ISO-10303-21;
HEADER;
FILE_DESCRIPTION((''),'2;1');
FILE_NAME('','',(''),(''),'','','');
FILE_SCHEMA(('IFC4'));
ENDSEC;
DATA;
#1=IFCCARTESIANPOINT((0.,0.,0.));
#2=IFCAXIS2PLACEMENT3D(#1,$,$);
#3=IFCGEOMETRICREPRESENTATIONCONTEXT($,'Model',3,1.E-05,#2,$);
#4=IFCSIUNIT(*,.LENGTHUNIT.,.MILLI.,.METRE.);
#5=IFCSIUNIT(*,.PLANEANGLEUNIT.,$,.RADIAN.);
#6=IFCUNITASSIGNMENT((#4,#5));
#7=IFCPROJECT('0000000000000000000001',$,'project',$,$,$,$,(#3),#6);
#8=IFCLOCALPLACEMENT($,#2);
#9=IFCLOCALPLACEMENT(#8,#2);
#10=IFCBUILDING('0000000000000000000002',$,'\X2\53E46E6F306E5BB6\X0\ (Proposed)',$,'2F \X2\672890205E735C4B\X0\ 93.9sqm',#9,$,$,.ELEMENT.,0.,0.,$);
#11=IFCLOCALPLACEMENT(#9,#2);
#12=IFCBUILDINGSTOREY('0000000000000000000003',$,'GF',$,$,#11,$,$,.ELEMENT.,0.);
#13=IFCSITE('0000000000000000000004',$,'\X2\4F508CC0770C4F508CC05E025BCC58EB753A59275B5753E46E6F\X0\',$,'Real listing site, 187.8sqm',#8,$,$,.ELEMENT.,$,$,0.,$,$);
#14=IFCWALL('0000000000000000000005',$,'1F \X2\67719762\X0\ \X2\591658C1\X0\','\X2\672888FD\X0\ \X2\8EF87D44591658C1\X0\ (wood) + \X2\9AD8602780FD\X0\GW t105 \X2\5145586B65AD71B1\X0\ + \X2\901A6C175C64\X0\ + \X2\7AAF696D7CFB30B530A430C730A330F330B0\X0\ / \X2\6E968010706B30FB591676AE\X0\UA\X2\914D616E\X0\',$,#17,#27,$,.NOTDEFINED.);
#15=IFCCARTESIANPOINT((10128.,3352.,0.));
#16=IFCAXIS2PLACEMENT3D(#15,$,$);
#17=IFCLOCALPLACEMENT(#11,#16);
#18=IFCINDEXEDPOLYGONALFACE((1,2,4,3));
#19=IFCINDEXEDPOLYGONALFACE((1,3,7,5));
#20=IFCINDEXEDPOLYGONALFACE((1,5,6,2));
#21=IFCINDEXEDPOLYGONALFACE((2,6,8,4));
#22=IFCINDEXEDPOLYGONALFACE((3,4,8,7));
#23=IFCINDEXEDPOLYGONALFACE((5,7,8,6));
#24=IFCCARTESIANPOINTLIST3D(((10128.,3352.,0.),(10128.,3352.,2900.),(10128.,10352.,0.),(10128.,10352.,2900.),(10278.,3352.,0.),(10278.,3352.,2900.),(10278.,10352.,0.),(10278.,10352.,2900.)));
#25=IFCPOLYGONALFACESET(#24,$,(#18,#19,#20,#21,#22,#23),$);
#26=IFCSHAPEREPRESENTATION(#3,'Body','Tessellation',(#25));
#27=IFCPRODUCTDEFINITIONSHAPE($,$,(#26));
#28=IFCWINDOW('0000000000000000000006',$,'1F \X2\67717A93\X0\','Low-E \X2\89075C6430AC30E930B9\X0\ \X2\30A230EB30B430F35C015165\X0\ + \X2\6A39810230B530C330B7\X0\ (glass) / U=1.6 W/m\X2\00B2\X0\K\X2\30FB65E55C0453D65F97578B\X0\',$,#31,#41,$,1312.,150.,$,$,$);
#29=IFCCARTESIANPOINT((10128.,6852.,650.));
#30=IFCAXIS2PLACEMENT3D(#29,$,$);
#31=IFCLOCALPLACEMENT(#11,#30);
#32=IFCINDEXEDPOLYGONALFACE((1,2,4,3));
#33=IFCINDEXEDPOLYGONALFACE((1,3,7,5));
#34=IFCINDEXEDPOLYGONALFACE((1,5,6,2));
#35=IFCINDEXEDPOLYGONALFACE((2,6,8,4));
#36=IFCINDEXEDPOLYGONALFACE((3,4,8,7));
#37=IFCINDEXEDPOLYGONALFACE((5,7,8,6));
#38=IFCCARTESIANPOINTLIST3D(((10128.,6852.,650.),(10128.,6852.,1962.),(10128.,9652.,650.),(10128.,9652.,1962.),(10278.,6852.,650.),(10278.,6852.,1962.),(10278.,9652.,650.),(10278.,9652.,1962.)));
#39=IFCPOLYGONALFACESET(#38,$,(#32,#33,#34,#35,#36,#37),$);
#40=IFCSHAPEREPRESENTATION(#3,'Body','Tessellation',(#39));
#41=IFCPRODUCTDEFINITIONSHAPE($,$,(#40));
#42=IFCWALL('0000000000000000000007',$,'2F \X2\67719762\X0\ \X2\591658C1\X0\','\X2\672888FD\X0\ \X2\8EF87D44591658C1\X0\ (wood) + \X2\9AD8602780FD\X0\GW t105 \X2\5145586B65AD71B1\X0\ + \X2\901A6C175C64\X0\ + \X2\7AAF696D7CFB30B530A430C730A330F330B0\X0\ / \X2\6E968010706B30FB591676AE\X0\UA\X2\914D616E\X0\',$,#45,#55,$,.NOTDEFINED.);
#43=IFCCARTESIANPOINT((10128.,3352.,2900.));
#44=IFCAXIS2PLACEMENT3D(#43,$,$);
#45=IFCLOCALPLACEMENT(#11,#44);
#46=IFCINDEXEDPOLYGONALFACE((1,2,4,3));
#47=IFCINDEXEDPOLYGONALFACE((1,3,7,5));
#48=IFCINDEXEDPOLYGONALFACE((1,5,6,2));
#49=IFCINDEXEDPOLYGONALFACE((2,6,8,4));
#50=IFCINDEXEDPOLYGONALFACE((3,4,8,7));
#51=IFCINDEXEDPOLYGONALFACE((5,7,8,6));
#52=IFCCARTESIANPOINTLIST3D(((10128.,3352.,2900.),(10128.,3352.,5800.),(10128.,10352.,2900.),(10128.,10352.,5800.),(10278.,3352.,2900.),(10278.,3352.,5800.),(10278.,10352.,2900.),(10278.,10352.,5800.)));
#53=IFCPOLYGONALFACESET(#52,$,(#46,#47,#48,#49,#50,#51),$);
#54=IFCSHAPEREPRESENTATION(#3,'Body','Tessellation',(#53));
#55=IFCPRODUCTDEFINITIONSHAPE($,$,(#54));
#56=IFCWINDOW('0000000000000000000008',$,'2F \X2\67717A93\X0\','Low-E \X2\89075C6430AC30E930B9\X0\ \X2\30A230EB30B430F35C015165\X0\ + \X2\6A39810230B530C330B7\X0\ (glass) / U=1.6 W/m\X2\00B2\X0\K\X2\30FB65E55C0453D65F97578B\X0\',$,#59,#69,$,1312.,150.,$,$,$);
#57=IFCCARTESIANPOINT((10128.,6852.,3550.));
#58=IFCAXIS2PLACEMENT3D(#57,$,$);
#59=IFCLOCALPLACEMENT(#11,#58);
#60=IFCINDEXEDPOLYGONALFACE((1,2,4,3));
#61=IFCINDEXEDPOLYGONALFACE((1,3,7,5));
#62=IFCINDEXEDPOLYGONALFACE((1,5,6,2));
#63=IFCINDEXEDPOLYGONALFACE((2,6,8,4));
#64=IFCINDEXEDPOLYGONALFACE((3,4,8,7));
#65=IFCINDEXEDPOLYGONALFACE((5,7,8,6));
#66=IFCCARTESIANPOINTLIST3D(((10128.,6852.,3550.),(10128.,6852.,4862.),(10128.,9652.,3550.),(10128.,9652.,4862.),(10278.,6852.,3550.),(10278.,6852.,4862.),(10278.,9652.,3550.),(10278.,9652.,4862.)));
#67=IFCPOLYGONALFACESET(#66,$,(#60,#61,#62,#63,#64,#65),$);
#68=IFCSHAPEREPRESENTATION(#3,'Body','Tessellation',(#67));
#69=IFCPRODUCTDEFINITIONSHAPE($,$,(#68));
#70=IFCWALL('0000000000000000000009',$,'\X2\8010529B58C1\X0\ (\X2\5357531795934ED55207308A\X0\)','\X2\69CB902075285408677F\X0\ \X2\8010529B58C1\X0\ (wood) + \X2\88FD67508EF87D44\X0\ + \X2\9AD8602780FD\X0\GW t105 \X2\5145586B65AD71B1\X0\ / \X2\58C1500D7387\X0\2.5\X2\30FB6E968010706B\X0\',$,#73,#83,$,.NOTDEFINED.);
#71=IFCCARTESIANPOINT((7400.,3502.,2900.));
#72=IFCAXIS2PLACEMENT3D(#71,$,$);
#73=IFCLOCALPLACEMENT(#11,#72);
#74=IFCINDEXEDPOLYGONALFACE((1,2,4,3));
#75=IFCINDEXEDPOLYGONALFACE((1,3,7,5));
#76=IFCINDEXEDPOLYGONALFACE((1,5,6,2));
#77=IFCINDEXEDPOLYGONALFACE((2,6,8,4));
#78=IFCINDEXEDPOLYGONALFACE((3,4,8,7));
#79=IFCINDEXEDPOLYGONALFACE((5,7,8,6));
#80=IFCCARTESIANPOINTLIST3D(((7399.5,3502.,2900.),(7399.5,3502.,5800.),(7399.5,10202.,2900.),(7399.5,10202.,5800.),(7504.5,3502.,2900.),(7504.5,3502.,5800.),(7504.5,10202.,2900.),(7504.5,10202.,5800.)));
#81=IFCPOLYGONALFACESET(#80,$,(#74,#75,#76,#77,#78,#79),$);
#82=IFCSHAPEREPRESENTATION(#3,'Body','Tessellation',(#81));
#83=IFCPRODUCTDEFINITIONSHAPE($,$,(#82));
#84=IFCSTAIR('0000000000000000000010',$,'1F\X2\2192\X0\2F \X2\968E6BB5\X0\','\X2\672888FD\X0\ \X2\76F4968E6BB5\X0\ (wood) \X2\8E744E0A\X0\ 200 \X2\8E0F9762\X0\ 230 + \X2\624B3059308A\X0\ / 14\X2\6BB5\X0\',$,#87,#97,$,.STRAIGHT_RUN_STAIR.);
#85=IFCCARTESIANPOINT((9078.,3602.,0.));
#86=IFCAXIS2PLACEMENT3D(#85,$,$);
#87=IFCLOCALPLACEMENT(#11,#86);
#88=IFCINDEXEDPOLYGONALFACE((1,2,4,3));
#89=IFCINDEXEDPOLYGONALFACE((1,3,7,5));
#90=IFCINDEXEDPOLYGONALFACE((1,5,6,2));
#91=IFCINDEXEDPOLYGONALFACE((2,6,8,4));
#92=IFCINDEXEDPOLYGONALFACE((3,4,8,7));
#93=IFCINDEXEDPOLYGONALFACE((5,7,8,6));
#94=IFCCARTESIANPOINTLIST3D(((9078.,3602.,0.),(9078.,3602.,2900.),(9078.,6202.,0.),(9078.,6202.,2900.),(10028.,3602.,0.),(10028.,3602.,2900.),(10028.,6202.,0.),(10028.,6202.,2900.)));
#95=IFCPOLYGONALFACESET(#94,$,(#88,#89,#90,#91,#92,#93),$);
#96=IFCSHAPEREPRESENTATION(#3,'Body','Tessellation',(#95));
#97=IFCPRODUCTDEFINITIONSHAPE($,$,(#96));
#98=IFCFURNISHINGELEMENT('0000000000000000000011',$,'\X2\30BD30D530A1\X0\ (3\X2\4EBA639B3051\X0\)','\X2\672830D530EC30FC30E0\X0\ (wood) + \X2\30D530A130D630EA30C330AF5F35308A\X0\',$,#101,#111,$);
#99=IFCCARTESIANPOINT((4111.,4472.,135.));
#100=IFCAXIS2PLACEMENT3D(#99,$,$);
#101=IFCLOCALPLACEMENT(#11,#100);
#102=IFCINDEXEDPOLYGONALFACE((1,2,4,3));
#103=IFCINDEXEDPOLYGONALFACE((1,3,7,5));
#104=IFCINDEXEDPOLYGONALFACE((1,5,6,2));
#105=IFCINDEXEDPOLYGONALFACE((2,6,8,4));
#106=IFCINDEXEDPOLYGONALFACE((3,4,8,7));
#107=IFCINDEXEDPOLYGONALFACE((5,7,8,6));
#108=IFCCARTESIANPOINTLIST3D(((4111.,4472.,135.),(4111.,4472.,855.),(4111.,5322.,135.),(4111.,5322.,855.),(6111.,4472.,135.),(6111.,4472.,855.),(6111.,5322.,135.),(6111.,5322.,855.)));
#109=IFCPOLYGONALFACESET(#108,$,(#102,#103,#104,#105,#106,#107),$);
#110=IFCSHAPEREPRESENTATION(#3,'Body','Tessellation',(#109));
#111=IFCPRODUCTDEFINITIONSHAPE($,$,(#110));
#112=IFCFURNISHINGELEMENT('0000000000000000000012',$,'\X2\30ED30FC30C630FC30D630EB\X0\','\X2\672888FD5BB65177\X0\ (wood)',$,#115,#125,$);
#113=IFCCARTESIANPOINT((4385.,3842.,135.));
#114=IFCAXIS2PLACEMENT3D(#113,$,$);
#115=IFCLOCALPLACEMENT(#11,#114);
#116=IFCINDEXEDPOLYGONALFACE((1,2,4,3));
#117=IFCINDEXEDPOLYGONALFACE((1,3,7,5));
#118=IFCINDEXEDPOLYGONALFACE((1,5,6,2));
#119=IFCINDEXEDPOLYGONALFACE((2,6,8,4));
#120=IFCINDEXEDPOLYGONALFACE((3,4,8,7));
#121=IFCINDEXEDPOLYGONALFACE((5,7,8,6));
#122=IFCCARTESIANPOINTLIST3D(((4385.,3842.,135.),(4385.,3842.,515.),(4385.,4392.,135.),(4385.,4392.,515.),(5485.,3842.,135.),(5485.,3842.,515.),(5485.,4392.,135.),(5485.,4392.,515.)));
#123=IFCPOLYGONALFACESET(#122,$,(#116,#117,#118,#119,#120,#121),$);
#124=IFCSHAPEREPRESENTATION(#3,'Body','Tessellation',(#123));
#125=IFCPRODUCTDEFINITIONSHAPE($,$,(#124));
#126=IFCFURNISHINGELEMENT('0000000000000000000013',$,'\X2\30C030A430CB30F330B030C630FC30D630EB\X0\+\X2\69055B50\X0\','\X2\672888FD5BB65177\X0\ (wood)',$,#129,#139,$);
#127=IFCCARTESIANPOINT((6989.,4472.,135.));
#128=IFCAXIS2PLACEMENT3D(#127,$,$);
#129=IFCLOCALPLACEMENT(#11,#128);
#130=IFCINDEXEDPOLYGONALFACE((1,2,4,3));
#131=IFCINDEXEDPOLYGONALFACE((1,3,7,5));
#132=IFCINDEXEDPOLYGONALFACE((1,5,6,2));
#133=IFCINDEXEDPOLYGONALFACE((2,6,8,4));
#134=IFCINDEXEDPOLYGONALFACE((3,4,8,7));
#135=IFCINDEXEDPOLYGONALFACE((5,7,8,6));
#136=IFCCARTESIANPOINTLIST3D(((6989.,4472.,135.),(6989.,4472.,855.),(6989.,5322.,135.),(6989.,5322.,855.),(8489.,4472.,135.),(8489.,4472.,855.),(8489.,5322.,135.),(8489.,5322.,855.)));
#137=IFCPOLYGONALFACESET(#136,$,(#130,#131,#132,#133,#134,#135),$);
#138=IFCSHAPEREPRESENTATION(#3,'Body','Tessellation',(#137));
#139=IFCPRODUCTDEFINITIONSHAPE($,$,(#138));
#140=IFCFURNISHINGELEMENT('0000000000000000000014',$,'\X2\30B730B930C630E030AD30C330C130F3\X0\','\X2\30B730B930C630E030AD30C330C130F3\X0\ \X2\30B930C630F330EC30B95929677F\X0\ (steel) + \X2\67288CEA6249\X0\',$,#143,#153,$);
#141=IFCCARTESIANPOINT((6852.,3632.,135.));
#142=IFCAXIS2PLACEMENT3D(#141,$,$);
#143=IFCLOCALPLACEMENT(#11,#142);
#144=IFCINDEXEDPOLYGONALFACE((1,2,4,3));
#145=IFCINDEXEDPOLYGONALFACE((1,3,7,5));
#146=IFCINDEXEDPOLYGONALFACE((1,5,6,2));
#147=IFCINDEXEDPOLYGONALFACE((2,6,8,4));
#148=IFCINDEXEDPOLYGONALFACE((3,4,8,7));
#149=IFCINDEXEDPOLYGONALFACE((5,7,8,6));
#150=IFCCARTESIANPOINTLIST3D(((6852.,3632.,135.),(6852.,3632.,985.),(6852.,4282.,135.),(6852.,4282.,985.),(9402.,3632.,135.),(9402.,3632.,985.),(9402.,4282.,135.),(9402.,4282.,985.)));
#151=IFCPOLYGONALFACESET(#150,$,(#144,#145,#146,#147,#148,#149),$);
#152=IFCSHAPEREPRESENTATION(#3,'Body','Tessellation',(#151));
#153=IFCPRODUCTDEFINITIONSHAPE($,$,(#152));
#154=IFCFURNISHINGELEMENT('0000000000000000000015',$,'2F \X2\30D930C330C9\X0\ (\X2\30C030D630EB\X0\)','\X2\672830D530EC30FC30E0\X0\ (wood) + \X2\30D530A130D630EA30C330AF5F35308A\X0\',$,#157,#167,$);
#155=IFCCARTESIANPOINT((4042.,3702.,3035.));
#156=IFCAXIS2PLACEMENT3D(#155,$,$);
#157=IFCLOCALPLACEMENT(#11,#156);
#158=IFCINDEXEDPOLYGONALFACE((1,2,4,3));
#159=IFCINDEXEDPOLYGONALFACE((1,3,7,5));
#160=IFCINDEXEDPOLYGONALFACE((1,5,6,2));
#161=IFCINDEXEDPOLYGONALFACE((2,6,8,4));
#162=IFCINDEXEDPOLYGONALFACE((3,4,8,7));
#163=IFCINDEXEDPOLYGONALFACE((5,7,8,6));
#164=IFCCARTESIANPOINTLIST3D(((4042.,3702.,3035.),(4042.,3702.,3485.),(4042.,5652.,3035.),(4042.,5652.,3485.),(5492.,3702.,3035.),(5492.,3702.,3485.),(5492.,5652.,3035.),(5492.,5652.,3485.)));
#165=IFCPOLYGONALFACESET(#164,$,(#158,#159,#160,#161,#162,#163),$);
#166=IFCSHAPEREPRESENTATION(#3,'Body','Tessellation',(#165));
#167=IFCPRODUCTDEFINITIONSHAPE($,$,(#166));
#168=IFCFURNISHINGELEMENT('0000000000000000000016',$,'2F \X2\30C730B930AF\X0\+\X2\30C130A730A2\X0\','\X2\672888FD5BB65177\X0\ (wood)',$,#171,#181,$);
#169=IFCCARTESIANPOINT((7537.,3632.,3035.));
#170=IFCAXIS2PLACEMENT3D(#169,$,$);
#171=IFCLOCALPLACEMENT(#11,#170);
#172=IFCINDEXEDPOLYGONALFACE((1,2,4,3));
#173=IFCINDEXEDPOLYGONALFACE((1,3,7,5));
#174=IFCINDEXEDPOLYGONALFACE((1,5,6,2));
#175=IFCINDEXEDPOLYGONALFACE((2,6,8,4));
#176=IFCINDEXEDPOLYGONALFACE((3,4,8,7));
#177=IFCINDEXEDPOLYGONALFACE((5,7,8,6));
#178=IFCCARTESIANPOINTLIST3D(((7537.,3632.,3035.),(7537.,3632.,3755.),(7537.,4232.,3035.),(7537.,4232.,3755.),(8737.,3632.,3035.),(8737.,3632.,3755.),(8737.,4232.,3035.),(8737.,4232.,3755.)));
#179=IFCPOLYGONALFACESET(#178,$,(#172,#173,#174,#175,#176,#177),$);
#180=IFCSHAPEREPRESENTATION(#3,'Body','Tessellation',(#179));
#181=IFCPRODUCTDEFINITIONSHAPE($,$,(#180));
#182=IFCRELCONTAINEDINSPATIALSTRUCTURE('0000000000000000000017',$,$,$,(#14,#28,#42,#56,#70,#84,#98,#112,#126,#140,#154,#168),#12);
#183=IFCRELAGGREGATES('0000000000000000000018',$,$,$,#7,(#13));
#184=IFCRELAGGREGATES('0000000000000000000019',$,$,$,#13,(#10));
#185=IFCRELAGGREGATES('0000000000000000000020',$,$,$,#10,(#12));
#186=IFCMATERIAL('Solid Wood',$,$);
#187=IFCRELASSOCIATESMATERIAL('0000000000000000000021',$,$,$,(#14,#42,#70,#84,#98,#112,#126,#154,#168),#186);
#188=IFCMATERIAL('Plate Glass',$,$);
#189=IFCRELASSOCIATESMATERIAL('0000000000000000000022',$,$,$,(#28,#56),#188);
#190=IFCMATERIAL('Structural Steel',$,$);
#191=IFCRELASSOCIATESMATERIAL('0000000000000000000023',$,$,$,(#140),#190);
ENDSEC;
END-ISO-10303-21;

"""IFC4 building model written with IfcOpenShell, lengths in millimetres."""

from ifc_helpers import new_model, si_unit, frame, frame_2d, origin, place, context, project, spatial, rectangle, extrude, material, element, fill, save


model = new_model("IFC4")

# Units and contexts
model_context = context("Model", 3, precision=1e-05, world=origin())
ifc_project = project(units=[si_unit("LENGTHUNIT", "METRE", prefix="MILLI"), si_unit("PLANEANGLEUNIT", "RADIAN")], contexts=[model_context])

# Site, building, storey
site_placement = place(None, origin())
site = spatial("IfcSite", under=ifc_project, at=site_placement, Name="佐賀県佐賀市富士町大字古湯", ObjectType="Real listing site, 187.8sqm", CompositionType="ELEMENT", RefElevation=0.0)
building_placement = place(site_placement, origin())
building = spatial("IfcBuilding", under=site, at=building_placement, Name="古湯の家 (Proposed)", ObjectType="2F 木造平屋 93.9sqm", CompositionType="ELEMENT", ElevationOfRefHeight=0.0, ElevationOfTerrain=0.0)
storey_placement = place(building_placement, origin())
storey = spatial("IfcBuildingStorey", under=building, at=storey_placement, Name="GF", CompositionType="ELEMENT", Elevation=0.0)

# Wall, opening, window
ifc_material_1 = material(Name="Solid Wood")
wall_1_placement = place(storey_placement, frame((10128.0, 3352.0, 0.0)))
wall_1 = element("IfcWall", 1, at=wall_1_placement, inside=storey, material=ifc_material_1, Name="1F 東面 外壁", Description="木製 軸組外壁 (wood) + 高性能GW t105 充填断熱 + 通気層 + 窯業系サイディング / 準耐火・外皮UA配慮", PredefinedType="NOTDEFINED", context=model_context, shape_type="SweptSolid", body=[
    extrude(rectangle(XDim=150.0, YDim=7000.0, at=frame_2d((75.0, 3500.0))), frame((10128.0, 3352.0, 0.0)), (0.0, 0.0, 1.0), 2900.0),
])
opening_1_placement = place(storey_placement, frame((10128.0, 6852.0, 650.0)))
opening_1 = element("IfcOpeningElement", 2, at=opening_1_placement, cuts=wall_1, PredefinedType="NOTDEFINED", context=model_context, shape_type="SweptSolid", body=[
    extrude(rectangle(XDim=150.0, YDim=2800.0, at=frame_2d((75.0, 1400.0))), frame((10128.0, 6852.0, 650.0)), (0.0, 0.0, 1.0), 1312.0),
])
ifc_material_2 = material(Name="Plate Glass")
window_1_placement = place(storey_placement, frame((10128.0, 6852.0, 650.0)))
window_1 = element("IfcWindow", 3, at=window_1_placement, inside=storey, material=ifc_material_2, Name="1F 東窓", Description="Low-E 複層ガラス アルゴン封入 + 樹脂サッシ (glass) / U=1.6 W/m²K・日射取得型", OverallHeight=1312.0, OverallWidth=150.0, context=model_context, shape_type="SweptSolid", body=[
    extrude(rectangle(XDim=150.0, YDim=2800.0, at=frame_2d((75.0, 1400.0))), frame((10128.0, 6852.0, 650.0)), (0.0, 0.0, 1.0), 1312.0),
])
fill(opening_1, window_1)

# Wall, opening, window
wall_2_placement = place(storey_placement, frame((10128.0, 3352.0, 2900.0)))
wall_2 = element("IfcWall", 4, at=wall_2_placement, inside=storey, material=ifc_material_1, Name="2F 東面 外壁", Description="木製 軸組外壁 (wood) + 高性能GW t105 充填断熱 + 通気層 + 窯業系サイディング / 準耐火・外皮UA配慮", PredefinedType="NOTDEFINED", context=model_context, shape_type="SweptSolid", body=[
    extrude(rectangle(XDim=150.0, YDim=7000.0, at=frame_2d((75.0, 3500.0))), frame((10128.0, 3352.0, 2900.0)), (0.0, 0.0, 1.0), 2900.0),
])
opening_2_placement = place(storey_placement, frame((10128.0, 6852.0, 3550.0)))
opening_2 = element("IfcOpeningElement", 5, at=opening_2_placement, cuts=wall_2, PredefinedType="NOTDEFINED", context=model_context, shape_type="SweptSolid", body=[
    extrude(rectangle(XDim=150.0, YDim=2800.0, at=frame_2d((75.0, 1400.0))), frame((10128.0, 6852.0, 3550.0)), (0.0, 0.0, 1.0), 1312.0),
])
window_2_placement = place(storey_placement, frame((10128.0, 6852.0, 3550.0)))
window_2 = element("IfcWindow", 6, at=window_2_placement, inside=storey, material=ifc_material_2, Name="2F 東窓", Description="Low-E 複層ガラス アルゴン封入 + 樹脂サッシ (glass) / U=1.6 W/m²K・日射取得型", OverallHeight=1312.0, OverallWidth=150.0, context=model_context, shape_type="SweptSolid", body=[
    extrude(rectangle(XDim=150.0, YDim=2800.0, at=frame_2d((75.0, 1400.0))), frame((10128.0, 6852.0, 3550.0)), (0.0, 0.0, 1.0), 1312.0),
])
fill(opening_2, window_2)

# Wall
wall_3_placement = place(storey_placement, frame((7400.0, 3502.0, 2900.0)))
element("IfcWall", 7, at=wall_3_placement, inside=storey, material=ifc_material_1, Name="耐力壁 (南北間仕切り)", Description="構造用合板 耐力壁 (wood) + 製材軸組 + 高性能GW t105 充填断熱 / 壁倍率2.5・準耐火", PredefinedType="NOTDEFINED", context=model_context, shape_type="SweptSolid", body=[
    extrude(rectangle(XDim=105.0, YDim=6700.0, at=frame_2d((52.0, 3350.0))), frame((7400.0, 3502.0, 2900.0)), (0.0, 0.0, 1.0), 2900.0),
])

# Stair
stair_placement = place(storey_placement, frame((9078.0, 3602.0, 0.0)))
element("IfcStair", 8, at=stair_placement, inside=storey, material=ifc_material_1, Name="1F→2F 階段", Description="木製 直階段 (wood) 蹴上 200 踏面 230 + 手すり / 14段", PredefinedType="STRAIGHT_RUN_STAIR", context=model_context, shape_type="SweptSolid", body=[
    extrude(rectangle(XDim=950.0, YDim=2600.0, at=frame_2d((475.0, 1300.0))), frame((9078.0, 3602.0, 0.0)), (0.0, 0.0, 1.0), 2900.0),
])

# Furnishing elements
furnishing_1_placement = place(storey_placement, frame((4111.0, 4472.0, 135.0)))
element("IfcFurnishingElement", 9, at=furnishing_1_placement, inside=storey, material=ifc_material_1, Name="ソファ (3人掛け)", Description="木フレーム (wood) + ファブリック張り", context=model_context, shape_type="SweptSolid", body=[
    extrude(rectangle(XDim=2000.0, YDim=850.0, at=frame_2d((1000.0, 425.0))), frame((4111.0, 4472.0, 135.0)), (0.0, 0.0, 1.0), 720.0),
])
furnishing_2_placement = place(storey_placement, frame((4385.0, 3842.0, 135.0)))
element("IfcFurnishingElement", 10, at=furnishing_2_placement, inside=storey, material=ifc_material_1, Name="ローテーブル", Description="木製家具 (wood)", context=model_context, shape_type="SweptSolid", body=[
    extrude(rectangle(XDim=1100.0, YDim=550.0, at=frame_2d((550.0, 275.0))), frame((4385.0, 3842.0, 135.0)), (0.0, 0.0, 1.0), 380.0),
])
furnishing_3_placement = place(storey_placement, frame((6989.0, 4472.0, 135.0)))
element("IfcFurnishingElement", 11, at=furnishing_3_placement, inside=storey, material=ifc_material_1, Name="ダイニングテーブル+椅子", Description="木製家具 (wood)", context=model_context, shape_type="SweptSolid", body=[
    extrude(rectangle(XDim=1500.0, YDim=850.0, at=frame_2d((750.0, 425.0))), frame((6989.0, 4472.0, 135.0)), (0.0, 0.0, 1.0), 720.0),
])
ifc_material_3 = material(Name="Structural Steel")
furnishing_4_placement = place(storey_placement, frame((6852.0, 3632.0, 135.0)))
element("IfcFurnishingElement", 12, at=furnishing_4_placement, inside=storey, material=ifc_material_3, Name="システムキッチン", Description="システムキッチン ステンレス天板 (steel) + 木質扉", context=model_context, shape_type="SweptSolid", body=[
    extrude(rectangle(XDim=2550.0, YDim=650.0, at=frame_2d((1275.0, 325.0))), frame((6852.0, 3632.0, 135.0)), (0.0, 0.0, 1.0), 850.0),
])
furnishing_5_placement = place(storey_placement, frame((4042.0, 3702.0, 3035.0)))
element("IfcFurnishingElement", 13, at=furnishing_5_placement, inside=storey, material=ifc_material_1, Name="2F ベッド (ダブル)", Description="木フレーム (wood) + ファブリック張り", context=model_context, shape_type="SweptSolid", body=[
    extrude(rectangle(XDim=1450.0, YDim=1950.0, at=frame_2d((725.0, 975.0))), frame((4042.0, 3702.0, 3035.0)), (0.0, 0.0, 1.0), 450.0),
])
furnishing_6_placement = place(storey_placement, frame((7537.0, 3632.0, 3035.0)))
element("IfcFurnishingElement", 14, at=furnishing_6_placement, inside=storey, material=ifc_material_1, Name="2F デスク+チェア", Description="木製家具 (wood)", context=model_context, shape_type="SweptSolid", body=[
    extrude(rectangle(XDim=1200.0, YDim=600.0, at=frame_2d((600.0, 300.0))), frame((7537.0, 3632.0, 3035.0)), (0.0, 0.0, 1.0), 720.0),
])

save(model, "model.ifc")
